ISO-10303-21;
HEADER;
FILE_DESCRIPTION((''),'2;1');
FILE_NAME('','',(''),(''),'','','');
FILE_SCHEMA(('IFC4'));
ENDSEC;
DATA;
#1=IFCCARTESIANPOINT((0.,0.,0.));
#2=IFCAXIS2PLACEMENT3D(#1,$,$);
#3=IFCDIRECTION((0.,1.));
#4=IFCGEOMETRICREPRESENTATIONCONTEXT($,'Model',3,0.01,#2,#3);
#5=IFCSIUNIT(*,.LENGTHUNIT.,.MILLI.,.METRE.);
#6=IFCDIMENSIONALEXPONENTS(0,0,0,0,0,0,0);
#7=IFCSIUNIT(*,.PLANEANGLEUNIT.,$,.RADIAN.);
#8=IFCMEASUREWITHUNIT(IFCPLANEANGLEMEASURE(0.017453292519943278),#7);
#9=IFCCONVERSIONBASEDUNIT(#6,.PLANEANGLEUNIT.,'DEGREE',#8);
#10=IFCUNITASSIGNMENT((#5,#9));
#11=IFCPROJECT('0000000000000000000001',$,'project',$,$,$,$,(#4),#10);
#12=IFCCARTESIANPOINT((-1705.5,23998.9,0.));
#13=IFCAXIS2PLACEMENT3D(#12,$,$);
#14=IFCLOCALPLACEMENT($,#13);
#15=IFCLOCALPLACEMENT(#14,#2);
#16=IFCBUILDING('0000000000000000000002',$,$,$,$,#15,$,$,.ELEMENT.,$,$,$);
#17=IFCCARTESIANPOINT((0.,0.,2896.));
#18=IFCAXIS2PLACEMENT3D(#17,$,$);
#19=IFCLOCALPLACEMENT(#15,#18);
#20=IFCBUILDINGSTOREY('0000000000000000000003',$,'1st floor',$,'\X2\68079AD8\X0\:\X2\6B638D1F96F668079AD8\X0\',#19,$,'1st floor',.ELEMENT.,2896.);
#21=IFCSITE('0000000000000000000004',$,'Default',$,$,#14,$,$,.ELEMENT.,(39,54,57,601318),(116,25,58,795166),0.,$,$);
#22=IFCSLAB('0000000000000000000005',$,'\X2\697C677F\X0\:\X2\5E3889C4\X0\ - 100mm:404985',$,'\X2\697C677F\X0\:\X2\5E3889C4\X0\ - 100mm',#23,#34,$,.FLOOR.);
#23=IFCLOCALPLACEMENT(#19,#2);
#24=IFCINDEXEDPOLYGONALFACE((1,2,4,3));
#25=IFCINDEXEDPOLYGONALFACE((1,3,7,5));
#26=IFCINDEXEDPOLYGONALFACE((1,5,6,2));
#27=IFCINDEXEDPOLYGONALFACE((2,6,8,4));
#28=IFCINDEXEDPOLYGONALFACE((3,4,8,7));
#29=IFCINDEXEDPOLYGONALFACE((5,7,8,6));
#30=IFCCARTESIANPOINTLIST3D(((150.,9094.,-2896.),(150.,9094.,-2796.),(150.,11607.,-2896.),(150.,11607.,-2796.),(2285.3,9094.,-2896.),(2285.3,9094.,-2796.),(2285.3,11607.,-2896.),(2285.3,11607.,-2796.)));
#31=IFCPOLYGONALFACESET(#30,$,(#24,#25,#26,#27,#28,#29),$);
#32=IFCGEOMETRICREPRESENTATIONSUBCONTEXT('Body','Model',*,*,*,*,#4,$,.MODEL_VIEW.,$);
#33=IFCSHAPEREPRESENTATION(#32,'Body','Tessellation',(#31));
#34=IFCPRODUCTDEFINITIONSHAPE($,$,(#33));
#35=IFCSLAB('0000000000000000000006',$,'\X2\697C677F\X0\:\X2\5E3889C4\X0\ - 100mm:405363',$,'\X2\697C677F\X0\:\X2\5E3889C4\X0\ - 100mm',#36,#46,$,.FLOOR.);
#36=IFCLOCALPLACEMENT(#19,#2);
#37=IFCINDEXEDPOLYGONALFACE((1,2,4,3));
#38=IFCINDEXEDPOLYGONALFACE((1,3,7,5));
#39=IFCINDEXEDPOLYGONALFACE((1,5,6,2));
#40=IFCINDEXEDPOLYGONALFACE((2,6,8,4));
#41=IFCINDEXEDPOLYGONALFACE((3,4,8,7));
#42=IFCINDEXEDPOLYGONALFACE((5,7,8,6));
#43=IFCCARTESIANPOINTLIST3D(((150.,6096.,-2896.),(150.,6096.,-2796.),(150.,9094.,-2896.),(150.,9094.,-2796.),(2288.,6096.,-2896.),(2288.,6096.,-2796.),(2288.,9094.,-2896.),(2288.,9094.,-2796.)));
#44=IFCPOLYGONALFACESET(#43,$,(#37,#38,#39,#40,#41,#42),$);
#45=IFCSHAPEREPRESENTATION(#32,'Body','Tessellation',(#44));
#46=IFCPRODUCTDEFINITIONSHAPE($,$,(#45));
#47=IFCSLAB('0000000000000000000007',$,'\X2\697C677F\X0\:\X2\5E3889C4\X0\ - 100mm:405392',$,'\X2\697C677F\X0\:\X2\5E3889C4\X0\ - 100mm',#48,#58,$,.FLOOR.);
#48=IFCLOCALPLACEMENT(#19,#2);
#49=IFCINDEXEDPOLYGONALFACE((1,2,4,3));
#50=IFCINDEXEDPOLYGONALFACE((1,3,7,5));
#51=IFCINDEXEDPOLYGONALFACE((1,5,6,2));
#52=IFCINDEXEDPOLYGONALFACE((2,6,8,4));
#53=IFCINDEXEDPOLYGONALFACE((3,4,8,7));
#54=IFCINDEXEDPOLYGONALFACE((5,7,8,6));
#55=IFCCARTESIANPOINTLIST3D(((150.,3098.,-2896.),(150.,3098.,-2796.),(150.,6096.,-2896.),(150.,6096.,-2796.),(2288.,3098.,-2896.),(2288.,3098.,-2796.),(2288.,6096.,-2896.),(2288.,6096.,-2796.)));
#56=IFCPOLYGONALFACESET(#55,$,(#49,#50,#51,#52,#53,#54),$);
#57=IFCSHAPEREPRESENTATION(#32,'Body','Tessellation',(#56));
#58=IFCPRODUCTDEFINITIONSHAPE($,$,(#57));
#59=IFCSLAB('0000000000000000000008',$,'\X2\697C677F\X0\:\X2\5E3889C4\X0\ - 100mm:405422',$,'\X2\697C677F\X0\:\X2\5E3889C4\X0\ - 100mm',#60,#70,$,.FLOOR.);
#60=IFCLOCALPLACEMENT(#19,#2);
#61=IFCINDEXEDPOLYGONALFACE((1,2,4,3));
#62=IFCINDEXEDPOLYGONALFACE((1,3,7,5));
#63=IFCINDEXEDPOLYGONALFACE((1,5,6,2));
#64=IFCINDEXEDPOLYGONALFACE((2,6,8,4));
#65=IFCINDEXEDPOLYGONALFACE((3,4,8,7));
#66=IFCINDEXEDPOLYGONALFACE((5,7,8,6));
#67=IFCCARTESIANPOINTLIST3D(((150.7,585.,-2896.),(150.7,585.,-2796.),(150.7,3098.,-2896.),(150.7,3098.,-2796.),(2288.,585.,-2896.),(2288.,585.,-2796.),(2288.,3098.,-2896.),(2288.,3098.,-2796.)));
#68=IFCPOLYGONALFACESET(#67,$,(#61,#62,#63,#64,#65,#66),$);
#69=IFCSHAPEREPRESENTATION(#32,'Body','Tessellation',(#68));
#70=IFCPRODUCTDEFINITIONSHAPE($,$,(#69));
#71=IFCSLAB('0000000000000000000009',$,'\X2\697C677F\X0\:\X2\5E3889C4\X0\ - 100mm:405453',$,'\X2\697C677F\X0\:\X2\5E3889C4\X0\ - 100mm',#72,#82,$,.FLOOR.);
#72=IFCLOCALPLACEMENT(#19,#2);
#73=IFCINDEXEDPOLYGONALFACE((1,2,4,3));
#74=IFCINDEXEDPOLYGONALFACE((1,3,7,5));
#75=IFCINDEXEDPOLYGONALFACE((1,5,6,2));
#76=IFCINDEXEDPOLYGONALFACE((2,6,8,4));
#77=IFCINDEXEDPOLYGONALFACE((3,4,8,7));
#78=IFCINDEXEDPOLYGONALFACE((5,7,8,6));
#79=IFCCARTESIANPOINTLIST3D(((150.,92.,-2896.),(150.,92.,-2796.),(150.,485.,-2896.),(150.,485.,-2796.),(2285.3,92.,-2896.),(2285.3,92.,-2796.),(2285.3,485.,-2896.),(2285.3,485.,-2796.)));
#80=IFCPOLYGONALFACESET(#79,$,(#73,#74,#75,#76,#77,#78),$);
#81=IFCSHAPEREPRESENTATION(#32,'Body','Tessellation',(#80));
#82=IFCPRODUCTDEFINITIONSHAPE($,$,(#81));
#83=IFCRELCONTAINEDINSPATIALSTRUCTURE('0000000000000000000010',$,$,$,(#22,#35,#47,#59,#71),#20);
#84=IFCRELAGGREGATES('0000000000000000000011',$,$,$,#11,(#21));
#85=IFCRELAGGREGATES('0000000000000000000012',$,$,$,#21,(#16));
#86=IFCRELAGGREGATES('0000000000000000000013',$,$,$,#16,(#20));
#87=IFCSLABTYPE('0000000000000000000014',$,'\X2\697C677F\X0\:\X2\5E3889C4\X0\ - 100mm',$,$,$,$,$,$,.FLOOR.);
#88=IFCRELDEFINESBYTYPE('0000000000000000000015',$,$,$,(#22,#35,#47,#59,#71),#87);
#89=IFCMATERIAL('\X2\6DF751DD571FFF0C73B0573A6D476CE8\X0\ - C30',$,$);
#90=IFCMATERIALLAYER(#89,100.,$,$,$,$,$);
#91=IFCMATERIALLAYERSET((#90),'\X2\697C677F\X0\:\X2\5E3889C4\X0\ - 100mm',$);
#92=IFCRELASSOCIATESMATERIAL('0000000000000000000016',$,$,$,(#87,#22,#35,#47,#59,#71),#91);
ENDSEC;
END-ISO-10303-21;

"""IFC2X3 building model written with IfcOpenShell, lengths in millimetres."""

from ifc_helpers import new_model, entity, si_unit, converted_unit, direction, frame, frame_2d, origin, origin_2d_with_axis, place, context, subcontext, project, spatial, rectangle, extrude, material, layer, layer_set, layer_usage, type_object, element, save


model = new_model("IFC2X3")

# Units and contexts
model_context = context("Model", 3, precision=0.01, world=origin(), true_north=direction((0.0, 1.0)))
body_context = subcontext(model_context, "Body", "Model", "MODEL_VIEW")
ifc_project = project(units=[si_unit("LENGTHUNIT", "METRE", prefix="MILLI"), converted_unit("PLANEANGLEUNIT", "DEGREE", entity("IfcPlaneAngleMeasure", 0.017453292519943278), si_unit("PLANEANGLEUNIT", "RADIAN"), dimensions=[0, 0, 0, 0, 0, 0, 0])], contexts=[model_context])

# Site, building, storey
site_placement = place(None, frame((-1705.5, 23998.9, 0.0)))
site = spatial("IfcSite", under=ifc_project, at=site_placement, Name="Default", CompositionType="ELEMENT", RefLatitude=(39, 54, 57, 601318), RefLongitude=(116, 25, 58, 795166), RefElevation=0.0)
building_placement = place(site_placement, origin())
building = spatial("IfcBuilding", under=site, at=building_placement, CompositionType="ELEMENT")
storey_placement = place(building_placement, frame((0.0, 0.0, 2896.0)))
storey = spatial("IfcBuildingStorey", under=building, at=storey_placement, Name="1st floor", ObjectType="标高:正负零标高", LongName="1st floor", CompositionType="ELEMENT", Elevation=2896.0)

# Slabs
ifc_material_1 = material(Name="混凝土，现场浇注 - C30")
ifc_layer_1 = layer(ifc_material_1, 100.0)
ifc_layer_set_1 = layer_set([ifc_layer_1], Name="楼板:常规 - 100mm")
slab_type = type_object("IfcSlabType", Name="楼板:常规 - 100mm", PredefinedType="FLOOR", material=ifc_layer_set_1)
ifc_layer_usage_1 = layer_usage(ifc_layer_set_1, "AXIS3", "POSITIVE", 0.0)
slab_1_placement = place(storey_placement, origin())
element("IfcSlab", 1, at=slab_1_placement, inside=storey, type_object=slab_type, material=ifc_layer_usage_1, Name="楼板:常规 - 100mm:404985", ObjectType="楼板:常规 - 100mm", PredefinedType="FLOOR", context=body_context, shape_type="SweptSolid", body=[
    extrude(rectangle(XDim=2513.0, YDim=2135.3, at=frame_2d((0.0, 0.0), x_axis=(1.0, 0.0))), frame((1217.6, 10350.5, -2796.0), z_axis=(0.0, 0.0, -1.0), x_axis=(0.0, 1.0, 0.0)), (0.0, 0.0, 1.0), 100.0),
])
ifc_layer_usage_2 = layer_usage(ifc_layer_set_1, "AXIS3", "POSITIVE", 0.0)
slab_2_placement = place(storey_placement, origin())
element("IfcSlab", 2, at=slab_2_placement, inside=storey, type_object=slab_type, material=ifc_layer_usage_2, Name="楼板:常规 - 100mm:405363", ObjectType="楼板:常规 - 100mm", PredefinedType="FLOOR", context=body_context, shape_type="SweptSolid", body=[
    extrude(rectangle(XDim=2998.0, YDim=2138.0, at=origin_2d_with_axis()), frame((1219.0, 7595.0, -2796.0), z_axis=(0.0, 0.0, -1.0), x_axis=(0.0, 1.0, 0.0)), (0.0, 0.0, 1.0), 100.0),
])
ifc_layer_usage_3 = layer_usage(ifc_layer_set_1, "AXIS3", "POSITIVE", 0.0)
slab_3_placement = place(storey_placement, origin())
element("IfcSlab", 3, at=slab_3_placement, inside=storey, type_object=slab_type, material=ifc_layer_usage_3, Name="楼板:常规 - 100mm:405392", ObjectType="楼板:常规 - 100mm", PredefinedType="FLOOR", context=body_context, shape_type="SweptSolid", body=[
    extrude(rectangle(XDim=2998.0, YDim=2138.0, at=frame_2d((0.0, 0.0), x_axis=(1.0, 0.0))), frame((1219.0, 4597.0, -2796.0), z_axis=(0.0, 0.0, -1.0), x_axis=(0.0, 1.0, 0.0)), (0.0, 0.0, 1.0), 100.0),
])
ifc_layer_usage_4 = layer_usage(ifc_layer_set_1, "AXIS3", "POSITIVE", 0.0)
slab_4_placement = place(storey_placement, origin())
element("IfcSlab", 4, at=slab_4_placement, inside=storey, type_object=slab_type, material=ifc_layer_usage_4, Name="楼板:常规 - 100mm:405422", ObjectType="楼板:常规 - 100mm", PredefinedType="FLOOR", context=body_context, shape_type="SweptSolid", body=[
    extrude(rectangle(XDim=2513.0, YDim=2137.3, at=frame_2d((0.0, 0.0), x_axis=(1.0, 0.0))), frame((1219.3, 1841.5, -2796.0), z_axis=(0.0, 0.0, -1.0), x_axis=(0.0, 1.0, 0.0)), (0.0, 0.0, 1.0), 100.0),
])
ifc_layer_usage_5 = layer_usage(ifc_layer_set_1, "AXIS3", "POSITIVE", 0.0)
slab_5_placement = place(storey_placement, origin())
element("IfcSlab", 5, at=slab_5_placement, inside=storey, type_object=slab_type, material=ifc_layer_usage_5, Name="楼板:常规 - 100mm:405453", ObjectType="楼板:常规 - 100mm", PredefinedType="FLOOR", context=body_context, shape_type="SweptSolid", body=[
    extrude(rectangle(XDim=393.0, YDim=2135.3, at=frame_2d((0.0, 0.0), x_axis=(1.0, 0.0))), frame((1217.7, 288.5, -2796.0), z_axis=(0.0, 0.0, -1.0), x_axis=(0.0, 1.0, 0.0)), (0.0, 0.0, 1.0), 100.0),
])

save(model, "model.ifc")
